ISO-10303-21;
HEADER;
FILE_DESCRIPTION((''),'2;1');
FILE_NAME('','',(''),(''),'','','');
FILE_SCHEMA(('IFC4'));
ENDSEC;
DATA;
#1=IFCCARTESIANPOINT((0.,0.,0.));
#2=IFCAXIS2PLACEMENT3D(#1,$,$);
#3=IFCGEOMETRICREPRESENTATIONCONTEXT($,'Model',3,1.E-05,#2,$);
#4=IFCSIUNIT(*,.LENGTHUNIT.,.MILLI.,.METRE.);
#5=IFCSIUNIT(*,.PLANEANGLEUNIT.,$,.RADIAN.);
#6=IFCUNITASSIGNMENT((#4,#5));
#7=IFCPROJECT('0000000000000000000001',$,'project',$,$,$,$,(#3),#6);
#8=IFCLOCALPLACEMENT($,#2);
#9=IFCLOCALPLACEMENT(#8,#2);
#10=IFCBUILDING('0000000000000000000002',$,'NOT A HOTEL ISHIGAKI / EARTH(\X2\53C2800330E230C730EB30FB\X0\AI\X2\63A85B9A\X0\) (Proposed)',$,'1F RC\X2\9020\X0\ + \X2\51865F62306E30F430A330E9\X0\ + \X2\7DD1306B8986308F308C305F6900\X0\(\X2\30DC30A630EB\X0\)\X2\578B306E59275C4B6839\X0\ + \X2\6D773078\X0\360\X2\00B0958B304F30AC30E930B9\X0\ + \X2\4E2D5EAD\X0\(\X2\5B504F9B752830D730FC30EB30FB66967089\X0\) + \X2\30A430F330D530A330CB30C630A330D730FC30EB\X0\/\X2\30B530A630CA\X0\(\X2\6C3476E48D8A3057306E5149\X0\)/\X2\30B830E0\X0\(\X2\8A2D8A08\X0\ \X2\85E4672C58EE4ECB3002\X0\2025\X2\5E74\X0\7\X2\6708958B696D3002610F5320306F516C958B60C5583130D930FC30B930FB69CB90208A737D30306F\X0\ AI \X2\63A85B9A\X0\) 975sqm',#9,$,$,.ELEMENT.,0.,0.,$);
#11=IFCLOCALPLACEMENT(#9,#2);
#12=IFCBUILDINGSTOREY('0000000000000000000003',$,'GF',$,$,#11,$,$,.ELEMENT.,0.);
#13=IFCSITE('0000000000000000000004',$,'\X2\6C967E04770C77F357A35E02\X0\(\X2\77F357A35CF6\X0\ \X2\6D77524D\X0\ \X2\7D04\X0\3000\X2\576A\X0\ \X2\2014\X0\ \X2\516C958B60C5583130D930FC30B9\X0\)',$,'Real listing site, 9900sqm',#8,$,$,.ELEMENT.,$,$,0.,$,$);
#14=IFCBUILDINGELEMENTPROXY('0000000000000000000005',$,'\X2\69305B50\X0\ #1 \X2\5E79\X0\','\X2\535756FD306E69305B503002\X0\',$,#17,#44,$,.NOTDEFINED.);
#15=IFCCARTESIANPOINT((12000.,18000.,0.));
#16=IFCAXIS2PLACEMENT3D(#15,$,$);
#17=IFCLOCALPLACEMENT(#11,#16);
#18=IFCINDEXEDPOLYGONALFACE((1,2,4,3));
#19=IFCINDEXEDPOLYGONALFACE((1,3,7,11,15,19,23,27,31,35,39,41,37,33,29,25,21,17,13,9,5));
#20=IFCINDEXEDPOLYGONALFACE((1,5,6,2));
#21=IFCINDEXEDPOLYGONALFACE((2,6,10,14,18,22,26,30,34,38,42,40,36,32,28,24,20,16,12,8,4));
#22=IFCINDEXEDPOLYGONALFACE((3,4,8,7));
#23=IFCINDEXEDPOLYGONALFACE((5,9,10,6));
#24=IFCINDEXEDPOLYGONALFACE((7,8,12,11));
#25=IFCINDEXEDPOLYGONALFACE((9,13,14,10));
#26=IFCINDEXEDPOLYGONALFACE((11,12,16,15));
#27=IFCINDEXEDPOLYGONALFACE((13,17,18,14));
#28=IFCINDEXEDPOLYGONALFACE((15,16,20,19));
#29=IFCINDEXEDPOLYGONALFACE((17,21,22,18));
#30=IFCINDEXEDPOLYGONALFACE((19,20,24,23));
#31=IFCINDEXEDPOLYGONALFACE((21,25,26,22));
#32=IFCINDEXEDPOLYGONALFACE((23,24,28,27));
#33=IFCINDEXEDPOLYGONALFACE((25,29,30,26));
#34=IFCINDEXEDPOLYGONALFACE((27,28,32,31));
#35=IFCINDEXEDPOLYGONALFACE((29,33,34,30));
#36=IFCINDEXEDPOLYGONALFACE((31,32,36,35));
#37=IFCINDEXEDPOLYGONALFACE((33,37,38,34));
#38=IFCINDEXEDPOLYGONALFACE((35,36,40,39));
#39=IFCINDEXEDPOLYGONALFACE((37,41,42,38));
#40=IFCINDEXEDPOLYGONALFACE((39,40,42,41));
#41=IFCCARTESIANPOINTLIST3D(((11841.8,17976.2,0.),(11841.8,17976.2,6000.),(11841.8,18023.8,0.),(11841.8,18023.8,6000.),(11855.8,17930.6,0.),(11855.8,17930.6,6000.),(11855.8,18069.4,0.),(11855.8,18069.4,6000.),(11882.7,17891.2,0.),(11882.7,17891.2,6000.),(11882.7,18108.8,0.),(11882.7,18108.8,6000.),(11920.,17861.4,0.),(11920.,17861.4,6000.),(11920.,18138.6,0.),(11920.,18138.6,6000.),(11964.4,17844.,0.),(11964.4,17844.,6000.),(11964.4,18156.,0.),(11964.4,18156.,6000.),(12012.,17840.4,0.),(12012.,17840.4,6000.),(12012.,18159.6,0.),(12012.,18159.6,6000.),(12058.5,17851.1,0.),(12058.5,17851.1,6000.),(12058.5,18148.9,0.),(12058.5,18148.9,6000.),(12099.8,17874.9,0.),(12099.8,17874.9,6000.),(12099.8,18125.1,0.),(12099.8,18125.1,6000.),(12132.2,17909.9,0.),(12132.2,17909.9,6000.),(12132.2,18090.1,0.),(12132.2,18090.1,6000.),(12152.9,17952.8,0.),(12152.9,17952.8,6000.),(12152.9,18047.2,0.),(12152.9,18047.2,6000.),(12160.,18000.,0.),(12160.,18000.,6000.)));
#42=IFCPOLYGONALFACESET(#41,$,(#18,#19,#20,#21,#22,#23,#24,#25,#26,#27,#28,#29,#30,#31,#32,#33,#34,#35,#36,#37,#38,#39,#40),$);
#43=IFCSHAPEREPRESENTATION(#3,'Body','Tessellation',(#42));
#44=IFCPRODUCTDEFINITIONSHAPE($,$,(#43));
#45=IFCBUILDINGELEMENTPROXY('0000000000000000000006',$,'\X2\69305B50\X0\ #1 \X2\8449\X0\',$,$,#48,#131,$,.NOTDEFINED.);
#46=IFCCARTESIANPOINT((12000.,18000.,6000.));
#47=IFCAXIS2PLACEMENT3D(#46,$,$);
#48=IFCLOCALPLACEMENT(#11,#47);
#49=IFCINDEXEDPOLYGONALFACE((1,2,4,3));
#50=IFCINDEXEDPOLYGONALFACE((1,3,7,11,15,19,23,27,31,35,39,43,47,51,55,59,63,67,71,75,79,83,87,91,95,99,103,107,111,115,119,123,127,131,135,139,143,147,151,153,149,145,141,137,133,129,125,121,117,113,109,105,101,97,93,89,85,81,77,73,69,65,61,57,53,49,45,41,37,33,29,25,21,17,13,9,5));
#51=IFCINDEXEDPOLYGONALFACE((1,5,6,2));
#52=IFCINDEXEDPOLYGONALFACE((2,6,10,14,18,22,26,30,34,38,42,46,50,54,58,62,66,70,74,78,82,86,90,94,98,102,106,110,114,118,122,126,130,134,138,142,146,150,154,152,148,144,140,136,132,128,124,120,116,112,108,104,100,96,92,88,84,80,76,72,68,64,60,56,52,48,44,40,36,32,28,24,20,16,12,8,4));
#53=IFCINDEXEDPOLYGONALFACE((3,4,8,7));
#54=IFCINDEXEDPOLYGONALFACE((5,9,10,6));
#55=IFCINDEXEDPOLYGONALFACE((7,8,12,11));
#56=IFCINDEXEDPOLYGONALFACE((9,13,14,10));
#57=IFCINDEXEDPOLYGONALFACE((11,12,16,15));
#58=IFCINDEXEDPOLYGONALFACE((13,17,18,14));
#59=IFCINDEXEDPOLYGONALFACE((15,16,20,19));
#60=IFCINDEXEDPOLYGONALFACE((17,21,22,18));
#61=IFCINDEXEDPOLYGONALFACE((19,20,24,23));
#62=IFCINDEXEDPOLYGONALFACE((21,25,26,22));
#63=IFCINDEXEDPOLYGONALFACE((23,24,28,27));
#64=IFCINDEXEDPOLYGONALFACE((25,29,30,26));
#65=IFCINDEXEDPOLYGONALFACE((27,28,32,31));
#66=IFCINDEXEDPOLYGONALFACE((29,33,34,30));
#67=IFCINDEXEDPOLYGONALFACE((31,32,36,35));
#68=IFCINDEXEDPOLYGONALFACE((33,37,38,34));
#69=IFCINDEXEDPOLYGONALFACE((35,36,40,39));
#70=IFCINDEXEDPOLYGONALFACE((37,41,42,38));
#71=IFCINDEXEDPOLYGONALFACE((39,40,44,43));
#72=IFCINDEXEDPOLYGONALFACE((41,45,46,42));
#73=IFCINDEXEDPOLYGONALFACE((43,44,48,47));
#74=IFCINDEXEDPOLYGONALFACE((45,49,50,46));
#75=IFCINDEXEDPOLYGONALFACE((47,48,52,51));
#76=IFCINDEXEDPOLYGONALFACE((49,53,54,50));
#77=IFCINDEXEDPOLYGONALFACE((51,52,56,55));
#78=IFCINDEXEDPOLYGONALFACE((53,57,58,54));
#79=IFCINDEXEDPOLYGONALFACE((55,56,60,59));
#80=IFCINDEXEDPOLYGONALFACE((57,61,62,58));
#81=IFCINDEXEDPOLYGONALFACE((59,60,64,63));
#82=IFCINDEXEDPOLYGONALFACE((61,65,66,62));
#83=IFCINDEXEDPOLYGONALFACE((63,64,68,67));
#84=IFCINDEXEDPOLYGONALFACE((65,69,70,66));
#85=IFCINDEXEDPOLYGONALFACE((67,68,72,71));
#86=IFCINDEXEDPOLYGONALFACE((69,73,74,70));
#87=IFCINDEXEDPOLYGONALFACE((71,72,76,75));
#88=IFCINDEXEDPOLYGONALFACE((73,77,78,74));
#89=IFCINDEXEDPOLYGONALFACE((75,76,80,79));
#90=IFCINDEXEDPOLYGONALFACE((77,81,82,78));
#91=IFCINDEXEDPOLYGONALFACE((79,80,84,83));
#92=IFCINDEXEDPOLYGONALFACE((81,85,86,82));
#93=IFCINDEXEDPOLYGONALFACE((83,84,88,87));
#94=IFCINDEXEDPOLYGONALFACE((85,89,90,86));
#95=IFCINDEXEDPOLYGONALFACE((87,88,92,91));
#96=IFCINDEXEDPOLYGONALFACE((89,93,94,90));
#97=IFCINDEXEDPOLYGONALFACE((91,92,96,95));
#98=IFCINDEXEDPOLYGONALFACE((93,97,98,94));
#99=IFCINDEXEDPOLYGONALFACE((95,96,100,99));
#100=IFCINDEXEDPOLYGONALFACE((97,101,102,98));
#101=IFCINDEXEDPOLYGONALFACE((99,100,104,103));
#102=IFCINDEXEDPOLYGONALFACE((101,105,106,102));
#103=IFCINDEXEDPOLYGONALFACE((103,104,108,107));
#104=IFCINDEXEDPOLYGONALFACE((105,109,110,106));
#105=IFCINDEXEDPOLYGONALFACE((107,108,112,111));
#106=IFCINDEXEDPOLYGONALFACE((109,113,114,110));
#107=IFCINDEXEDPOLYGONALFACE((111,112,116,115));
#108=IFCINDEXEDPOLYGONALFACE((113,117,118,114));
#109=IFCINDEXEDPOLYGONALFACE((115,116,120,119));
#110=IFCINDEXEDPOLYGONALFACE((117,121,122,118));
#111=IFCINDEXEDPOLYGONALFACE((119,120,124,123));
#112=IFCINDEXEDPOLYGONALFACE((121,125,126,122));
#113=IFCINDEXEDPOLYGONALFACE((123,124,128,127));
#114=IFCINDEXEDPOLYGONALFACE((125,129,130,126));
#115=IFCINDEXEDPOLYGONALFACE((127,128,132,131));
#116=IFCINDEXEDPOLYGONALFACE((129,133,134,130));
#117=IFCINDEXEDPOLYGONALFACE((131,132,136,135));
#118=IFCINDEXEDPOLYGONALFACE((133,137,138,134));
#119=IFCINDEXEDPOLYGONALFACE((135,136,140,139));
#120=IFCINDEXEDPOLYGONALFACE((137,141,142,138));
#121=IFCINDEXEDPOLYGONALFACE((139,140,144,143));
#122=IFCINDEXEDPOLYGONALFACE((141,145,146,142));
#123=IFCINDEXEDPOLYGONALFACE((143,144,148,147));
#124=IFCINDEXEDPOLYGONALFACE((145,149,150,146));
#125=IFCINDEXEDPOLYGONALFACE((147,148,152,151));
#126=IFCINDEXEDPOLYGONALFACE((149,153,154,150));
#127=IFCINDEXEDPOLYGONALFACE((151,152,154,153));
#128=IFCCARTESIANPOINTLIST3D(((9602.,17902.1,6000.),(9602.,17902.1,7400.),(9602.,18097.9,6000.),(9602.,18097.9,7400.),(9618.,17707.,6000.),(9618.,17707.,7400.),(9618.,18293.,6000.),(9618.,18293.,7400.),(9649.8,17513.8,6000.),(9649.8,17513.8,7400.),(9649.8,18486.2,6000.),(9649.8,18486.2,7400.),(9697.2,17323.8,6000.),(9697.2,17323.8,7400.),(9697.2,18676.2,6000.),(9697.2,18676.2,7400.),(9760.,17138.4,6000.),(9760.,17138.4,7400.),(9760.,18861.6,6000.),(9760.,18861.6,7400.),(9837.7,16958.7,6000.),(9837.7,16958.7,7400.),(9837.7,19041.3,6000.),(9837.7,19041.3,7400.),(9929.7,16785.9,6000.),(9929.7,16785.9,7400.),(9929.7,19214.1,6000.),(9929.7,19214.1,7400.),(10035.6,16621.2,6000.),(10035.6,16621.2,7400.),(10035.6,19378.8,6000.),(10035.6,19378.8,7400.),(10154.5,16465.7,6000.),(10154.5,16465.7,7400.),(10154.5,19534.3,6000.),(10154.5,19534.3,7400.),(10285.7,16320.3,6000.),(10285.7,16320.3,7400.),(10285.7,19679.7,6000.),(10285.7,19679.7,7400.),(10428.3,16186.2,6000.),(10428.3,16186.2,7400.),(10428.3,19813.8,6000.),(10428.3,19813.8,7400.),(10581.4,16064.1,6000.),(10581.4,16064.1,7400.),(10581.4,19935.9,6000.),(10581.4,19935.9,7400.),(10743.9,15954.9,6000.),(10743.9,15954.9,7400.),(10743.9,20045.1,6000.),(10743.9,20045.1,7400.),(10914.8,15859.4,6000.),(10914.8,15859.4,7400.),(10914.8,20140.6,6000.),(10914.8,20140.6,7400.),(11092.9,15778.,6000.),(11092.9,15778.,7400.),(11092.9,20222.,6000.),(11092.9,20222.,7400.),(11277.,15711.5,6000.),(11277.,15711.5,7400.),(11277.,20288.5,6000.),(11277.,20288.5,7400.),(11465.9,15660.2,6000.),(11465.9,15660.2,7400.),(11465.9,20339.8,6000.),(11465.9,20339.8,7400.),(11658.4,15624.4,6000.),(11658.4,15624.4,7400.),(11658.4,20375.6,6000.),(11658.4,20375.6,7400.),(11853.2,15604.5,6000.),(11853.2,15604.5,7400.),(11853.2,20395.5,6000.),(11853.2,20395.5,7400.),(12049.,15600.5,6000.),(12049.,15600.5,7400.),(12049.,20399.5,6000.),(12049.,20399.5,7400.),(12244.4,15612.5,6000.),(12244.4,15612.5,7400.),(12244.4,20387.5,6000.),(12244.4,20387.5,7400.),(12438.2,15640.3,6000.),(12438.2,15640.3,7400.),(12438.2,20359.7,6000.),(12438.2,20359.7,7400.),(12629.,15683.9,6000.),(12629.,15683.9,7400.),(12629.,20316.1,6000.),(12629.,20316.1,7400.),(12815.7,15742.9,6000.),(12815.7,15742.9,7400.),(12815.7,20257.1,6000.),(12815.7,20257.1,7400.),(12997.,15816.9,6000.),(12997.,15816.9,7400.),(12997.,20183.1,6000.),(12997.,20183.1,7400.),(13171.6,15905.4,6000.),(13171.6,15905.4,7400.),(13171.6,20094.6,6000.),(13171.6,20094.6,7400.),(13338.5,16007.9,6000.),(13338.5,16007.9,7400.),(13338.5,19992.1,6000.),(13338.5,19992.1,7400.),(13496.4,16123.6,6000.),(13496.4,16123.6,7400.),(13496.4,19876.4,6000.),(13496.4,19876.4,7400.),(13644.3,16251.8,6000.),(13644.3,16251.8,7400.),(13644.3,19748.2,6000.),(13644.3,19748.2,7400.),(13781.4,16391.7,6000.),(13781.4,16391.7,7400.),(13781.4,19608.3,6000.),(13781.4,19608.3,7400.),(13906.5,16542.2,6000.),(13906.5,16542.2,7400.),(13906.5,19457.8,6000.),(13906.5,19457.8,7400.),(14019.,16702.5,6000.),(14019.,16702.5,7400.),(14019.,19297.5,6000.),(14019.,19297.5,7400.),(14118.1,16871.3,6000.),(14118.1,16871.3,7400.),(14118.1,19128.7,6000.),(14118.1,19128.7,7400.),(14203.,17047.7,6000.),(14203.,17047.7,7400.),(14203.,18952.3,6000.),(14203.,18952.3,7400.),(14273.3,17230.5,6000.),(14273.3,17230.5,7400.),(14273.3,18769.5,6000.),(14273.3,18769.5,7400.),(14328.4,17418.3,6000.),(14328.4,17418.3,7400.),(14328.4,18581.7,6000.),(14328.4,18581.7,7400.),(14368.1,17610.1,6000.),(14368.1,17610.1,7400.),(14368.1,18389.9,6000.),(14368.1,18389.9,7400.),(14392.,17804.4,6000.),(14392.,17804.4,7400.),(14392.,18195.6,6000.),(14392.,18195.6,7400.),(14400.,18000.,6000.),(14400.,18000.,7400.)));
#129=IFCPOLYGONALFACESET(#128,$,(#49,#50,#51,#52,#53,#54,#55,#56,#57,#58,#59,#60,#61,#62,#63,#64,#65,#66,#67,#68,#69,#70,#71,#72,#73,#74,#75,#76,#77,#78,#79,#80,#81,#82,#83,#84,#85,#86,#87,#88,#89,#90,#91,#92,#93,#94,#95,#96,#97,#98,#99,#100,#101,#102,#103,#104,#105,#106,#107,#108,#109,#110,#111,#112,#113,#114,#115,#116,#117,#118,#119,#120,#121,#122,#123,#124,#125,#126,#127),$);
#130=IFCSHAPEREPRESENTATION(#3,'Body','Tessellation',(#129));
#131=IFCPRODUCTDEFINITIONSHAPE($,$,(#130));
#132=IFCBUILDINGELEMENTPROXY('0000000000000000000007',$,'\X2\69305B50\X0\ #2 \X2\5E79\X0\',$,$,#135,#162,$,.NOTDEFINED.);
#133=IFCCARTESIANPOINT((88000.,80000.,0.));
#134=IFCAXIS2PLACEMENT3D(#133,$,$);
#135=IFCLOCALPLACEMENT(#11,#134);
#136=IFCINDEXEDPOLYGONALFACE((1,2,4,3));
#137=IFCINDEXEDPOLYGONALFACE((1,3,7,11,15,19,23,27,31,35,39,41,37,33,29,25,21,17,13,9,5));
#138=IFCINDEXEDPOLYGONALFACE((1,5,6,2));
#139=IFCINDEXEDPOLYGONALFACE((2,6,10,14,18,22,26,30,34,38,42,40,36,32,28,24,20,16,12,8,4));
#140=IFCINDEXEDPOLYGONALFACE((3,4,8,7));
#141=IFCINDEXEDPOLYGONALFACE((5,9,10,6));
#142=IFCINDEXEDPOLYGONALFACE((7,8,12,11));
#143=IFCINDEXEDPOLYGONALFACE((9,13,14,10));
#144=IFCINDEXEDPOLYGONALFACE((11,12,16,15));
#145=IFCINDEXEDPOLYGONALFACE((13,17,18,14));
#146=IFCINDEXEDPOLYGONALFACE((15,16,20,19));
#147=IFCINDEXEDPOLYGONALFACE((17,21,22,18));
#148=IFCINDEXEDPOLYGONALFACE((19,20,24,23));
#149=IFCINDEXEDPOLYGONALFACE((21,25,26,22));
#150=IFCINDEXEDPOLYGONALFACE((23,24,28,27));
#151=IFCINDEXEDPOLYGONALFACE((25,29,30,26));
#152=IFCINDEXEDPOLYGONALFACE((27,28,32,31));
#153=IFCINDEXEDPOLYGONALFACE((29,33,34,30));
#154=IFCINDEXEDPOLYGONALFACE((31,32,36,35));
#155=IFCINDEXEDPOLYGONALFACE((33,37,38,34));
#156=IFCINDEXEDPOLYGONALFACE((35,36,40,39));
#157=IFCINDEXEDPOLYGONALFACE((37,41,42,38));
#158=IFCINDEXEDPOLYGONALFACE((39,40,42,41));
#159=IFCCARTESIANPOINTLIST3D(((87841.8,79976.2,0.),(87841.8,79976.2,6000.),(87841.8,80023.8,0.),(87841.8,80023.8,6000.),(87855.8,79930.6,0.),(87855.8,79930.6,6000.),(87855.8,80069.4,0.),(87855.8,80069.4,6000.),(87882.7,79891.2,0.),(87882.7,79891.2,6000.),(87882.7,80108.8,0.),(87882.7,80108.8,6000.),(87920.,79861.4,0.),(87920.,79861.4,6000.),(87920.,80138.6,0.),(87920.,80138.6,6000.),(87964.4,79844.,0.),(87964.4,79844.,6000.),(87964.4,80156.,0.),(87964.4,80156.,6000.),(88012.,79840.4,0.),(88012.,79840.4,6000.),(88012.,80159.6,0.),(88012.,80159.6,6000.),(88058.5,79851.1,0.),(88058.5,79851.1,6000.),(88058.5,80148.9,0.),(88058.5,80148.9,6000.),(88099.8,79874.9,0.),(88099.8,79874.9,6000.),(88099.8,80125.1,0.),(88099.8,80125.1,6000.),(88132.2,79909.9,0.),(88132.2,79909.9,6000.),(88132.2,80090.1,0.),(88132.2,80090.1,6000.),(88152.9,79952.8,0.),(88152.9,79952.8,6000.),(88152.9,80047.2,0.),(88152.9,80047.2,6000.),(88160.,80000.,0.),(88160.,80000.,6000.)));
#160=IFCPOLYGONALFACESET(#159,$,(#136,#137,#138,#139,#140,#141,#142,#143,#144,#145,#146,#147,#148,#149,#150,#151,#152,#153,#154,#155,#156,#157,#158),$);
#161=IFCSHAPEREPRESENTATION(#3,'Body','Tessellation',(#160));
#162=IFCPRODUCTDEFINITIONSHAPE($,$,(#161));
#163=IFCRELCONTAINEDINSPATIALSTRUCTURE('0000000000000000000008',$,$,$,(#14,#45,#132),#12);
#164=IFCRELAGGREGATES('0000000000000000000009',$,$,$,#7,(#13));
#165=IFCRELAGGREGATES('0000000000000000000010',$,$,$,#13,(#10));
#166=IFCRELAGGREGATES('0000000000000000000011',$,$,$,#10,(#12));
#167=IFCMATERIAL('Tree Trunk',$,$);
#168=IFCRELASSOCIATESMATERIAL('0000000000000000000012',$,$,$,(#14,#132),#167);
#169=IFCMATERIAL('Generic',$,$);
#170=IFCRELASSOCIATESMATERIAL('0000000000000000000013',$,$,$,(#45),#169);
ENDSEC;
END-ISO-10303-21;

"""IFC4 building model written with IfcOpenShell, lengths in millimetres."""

from ifc_helpers import new_model, si_unit, frame, origin, origin_2d, place, context, project, spatial, circle, extrude, material, element, save


model = new_model("IFC4")

# Units and contexts
model_context = context("Model", 3, precision=1e-05, world=origin())
ifc_project = project(units=[si_unit("LENGTHUNIT", "METRE", prefix="MILLI"), si_unit("PLANEANGLEUNIT", "RADIAN")], contexts=[model_context])

# Site, building, storey
site_placement = place(None, origin())
site = spatial("IfcSite", under=ifc_project, at=site_placement, Name="沖縄県石垣市(石垣島 海前 約3000坪 — 公開情報ベース)", ObjectType="Real listing site, 9900sqm", CompositionType="ELEMENT", RefElevation=0.0)
building_placement = place(site_placement, origin())
building = spatial("IfcBuilding", under=site, at=building_placement, Name="NOT A HOTEL ISHIGAKI / EARTH(参考モデル・AI推定) (Proposed)", ObjectType="1F RC造 + 円形のヴィラ + 緑に覆われた椀(ボウル)型の大屋根 + 海へ360°開くガラス + 中庭(子供用プール・暖炉) + インフィニティプール/サウナ(水盤越しの光)/ジム(設計 藤本壮介。2025年7月開業。意匠は公開情報ベース・構造詳細は AI 推定) 975sqm", CompositionType="ELEMENT", ElevationOfRefHeight=0.0, ElevationOfTerrain=0.0)
storey_placement = place(building_placement, origin())
storey = spatial("IfcBuildingStorey", under=building, at=storey_placement, Name="GF", CompositionType="ELEMENT", Elevation=0.0)

# Shared definitions
ifc_material_1 = material(Name="Generic")

# Building element proxies
ifc_material_2 = material(Name="Tree Trunk")
proxy_1_placement = place(storey_placement, frame((12000.0, 18000.0, 0.0)))
element("IfcBuildingElementProxy", 1, at=proxy_1_placement, inside=storey, material=ifc_material_2, Name="椰子 #1 幹", Description="南国の椰子。", PredefinedType="NOTDEFINED", context=model_context, shape_type="SweptSolid", body=[
    extrude(circle(Radius=160.0, at=origin_2d()), frame((12000.0, 18000.0, 0.0)), (0.0, 0.0, 1.0), 6000.0),
])
proxy_2_placement = place(storey_placement, frame((12000.0, 18000.0, 6000.0)))
element("IfcBuildingElementProxy", 2, at=proxy_2_placement, inside=storey, material=ifc_material_1, Name="椰子 #1 葉", PredefinedType="NOTDEFINED", context=model_context, shape_type="SweptSolid", body=[
    extrude(circle(Radius=2400.0, at=origin_2d()), frame((12000.0, 18000.0, 6000.0)), (0.0, 0.0, 1.0), 1400.0),
])
proxy_3_placement = place(storey_placement, frame((88000.0, 80000.0, 0.0)))
element("IfcBuildingElementProxy", 3, at=proxy_3_placement, inside=storey, material=ifc_material_2, Name="椰子 #2 幹", PredefinedType="NOTDEFINED", context=model_context, shape_type="SweptSolid", body=[
    extrude(circle(Radius=160.0, at=origin_2d()), frame((88000.0, 80000.0, 0.0)), (0.0, 0.0, 1.0), 6000.0),
])

save(model, "model.ifc")
